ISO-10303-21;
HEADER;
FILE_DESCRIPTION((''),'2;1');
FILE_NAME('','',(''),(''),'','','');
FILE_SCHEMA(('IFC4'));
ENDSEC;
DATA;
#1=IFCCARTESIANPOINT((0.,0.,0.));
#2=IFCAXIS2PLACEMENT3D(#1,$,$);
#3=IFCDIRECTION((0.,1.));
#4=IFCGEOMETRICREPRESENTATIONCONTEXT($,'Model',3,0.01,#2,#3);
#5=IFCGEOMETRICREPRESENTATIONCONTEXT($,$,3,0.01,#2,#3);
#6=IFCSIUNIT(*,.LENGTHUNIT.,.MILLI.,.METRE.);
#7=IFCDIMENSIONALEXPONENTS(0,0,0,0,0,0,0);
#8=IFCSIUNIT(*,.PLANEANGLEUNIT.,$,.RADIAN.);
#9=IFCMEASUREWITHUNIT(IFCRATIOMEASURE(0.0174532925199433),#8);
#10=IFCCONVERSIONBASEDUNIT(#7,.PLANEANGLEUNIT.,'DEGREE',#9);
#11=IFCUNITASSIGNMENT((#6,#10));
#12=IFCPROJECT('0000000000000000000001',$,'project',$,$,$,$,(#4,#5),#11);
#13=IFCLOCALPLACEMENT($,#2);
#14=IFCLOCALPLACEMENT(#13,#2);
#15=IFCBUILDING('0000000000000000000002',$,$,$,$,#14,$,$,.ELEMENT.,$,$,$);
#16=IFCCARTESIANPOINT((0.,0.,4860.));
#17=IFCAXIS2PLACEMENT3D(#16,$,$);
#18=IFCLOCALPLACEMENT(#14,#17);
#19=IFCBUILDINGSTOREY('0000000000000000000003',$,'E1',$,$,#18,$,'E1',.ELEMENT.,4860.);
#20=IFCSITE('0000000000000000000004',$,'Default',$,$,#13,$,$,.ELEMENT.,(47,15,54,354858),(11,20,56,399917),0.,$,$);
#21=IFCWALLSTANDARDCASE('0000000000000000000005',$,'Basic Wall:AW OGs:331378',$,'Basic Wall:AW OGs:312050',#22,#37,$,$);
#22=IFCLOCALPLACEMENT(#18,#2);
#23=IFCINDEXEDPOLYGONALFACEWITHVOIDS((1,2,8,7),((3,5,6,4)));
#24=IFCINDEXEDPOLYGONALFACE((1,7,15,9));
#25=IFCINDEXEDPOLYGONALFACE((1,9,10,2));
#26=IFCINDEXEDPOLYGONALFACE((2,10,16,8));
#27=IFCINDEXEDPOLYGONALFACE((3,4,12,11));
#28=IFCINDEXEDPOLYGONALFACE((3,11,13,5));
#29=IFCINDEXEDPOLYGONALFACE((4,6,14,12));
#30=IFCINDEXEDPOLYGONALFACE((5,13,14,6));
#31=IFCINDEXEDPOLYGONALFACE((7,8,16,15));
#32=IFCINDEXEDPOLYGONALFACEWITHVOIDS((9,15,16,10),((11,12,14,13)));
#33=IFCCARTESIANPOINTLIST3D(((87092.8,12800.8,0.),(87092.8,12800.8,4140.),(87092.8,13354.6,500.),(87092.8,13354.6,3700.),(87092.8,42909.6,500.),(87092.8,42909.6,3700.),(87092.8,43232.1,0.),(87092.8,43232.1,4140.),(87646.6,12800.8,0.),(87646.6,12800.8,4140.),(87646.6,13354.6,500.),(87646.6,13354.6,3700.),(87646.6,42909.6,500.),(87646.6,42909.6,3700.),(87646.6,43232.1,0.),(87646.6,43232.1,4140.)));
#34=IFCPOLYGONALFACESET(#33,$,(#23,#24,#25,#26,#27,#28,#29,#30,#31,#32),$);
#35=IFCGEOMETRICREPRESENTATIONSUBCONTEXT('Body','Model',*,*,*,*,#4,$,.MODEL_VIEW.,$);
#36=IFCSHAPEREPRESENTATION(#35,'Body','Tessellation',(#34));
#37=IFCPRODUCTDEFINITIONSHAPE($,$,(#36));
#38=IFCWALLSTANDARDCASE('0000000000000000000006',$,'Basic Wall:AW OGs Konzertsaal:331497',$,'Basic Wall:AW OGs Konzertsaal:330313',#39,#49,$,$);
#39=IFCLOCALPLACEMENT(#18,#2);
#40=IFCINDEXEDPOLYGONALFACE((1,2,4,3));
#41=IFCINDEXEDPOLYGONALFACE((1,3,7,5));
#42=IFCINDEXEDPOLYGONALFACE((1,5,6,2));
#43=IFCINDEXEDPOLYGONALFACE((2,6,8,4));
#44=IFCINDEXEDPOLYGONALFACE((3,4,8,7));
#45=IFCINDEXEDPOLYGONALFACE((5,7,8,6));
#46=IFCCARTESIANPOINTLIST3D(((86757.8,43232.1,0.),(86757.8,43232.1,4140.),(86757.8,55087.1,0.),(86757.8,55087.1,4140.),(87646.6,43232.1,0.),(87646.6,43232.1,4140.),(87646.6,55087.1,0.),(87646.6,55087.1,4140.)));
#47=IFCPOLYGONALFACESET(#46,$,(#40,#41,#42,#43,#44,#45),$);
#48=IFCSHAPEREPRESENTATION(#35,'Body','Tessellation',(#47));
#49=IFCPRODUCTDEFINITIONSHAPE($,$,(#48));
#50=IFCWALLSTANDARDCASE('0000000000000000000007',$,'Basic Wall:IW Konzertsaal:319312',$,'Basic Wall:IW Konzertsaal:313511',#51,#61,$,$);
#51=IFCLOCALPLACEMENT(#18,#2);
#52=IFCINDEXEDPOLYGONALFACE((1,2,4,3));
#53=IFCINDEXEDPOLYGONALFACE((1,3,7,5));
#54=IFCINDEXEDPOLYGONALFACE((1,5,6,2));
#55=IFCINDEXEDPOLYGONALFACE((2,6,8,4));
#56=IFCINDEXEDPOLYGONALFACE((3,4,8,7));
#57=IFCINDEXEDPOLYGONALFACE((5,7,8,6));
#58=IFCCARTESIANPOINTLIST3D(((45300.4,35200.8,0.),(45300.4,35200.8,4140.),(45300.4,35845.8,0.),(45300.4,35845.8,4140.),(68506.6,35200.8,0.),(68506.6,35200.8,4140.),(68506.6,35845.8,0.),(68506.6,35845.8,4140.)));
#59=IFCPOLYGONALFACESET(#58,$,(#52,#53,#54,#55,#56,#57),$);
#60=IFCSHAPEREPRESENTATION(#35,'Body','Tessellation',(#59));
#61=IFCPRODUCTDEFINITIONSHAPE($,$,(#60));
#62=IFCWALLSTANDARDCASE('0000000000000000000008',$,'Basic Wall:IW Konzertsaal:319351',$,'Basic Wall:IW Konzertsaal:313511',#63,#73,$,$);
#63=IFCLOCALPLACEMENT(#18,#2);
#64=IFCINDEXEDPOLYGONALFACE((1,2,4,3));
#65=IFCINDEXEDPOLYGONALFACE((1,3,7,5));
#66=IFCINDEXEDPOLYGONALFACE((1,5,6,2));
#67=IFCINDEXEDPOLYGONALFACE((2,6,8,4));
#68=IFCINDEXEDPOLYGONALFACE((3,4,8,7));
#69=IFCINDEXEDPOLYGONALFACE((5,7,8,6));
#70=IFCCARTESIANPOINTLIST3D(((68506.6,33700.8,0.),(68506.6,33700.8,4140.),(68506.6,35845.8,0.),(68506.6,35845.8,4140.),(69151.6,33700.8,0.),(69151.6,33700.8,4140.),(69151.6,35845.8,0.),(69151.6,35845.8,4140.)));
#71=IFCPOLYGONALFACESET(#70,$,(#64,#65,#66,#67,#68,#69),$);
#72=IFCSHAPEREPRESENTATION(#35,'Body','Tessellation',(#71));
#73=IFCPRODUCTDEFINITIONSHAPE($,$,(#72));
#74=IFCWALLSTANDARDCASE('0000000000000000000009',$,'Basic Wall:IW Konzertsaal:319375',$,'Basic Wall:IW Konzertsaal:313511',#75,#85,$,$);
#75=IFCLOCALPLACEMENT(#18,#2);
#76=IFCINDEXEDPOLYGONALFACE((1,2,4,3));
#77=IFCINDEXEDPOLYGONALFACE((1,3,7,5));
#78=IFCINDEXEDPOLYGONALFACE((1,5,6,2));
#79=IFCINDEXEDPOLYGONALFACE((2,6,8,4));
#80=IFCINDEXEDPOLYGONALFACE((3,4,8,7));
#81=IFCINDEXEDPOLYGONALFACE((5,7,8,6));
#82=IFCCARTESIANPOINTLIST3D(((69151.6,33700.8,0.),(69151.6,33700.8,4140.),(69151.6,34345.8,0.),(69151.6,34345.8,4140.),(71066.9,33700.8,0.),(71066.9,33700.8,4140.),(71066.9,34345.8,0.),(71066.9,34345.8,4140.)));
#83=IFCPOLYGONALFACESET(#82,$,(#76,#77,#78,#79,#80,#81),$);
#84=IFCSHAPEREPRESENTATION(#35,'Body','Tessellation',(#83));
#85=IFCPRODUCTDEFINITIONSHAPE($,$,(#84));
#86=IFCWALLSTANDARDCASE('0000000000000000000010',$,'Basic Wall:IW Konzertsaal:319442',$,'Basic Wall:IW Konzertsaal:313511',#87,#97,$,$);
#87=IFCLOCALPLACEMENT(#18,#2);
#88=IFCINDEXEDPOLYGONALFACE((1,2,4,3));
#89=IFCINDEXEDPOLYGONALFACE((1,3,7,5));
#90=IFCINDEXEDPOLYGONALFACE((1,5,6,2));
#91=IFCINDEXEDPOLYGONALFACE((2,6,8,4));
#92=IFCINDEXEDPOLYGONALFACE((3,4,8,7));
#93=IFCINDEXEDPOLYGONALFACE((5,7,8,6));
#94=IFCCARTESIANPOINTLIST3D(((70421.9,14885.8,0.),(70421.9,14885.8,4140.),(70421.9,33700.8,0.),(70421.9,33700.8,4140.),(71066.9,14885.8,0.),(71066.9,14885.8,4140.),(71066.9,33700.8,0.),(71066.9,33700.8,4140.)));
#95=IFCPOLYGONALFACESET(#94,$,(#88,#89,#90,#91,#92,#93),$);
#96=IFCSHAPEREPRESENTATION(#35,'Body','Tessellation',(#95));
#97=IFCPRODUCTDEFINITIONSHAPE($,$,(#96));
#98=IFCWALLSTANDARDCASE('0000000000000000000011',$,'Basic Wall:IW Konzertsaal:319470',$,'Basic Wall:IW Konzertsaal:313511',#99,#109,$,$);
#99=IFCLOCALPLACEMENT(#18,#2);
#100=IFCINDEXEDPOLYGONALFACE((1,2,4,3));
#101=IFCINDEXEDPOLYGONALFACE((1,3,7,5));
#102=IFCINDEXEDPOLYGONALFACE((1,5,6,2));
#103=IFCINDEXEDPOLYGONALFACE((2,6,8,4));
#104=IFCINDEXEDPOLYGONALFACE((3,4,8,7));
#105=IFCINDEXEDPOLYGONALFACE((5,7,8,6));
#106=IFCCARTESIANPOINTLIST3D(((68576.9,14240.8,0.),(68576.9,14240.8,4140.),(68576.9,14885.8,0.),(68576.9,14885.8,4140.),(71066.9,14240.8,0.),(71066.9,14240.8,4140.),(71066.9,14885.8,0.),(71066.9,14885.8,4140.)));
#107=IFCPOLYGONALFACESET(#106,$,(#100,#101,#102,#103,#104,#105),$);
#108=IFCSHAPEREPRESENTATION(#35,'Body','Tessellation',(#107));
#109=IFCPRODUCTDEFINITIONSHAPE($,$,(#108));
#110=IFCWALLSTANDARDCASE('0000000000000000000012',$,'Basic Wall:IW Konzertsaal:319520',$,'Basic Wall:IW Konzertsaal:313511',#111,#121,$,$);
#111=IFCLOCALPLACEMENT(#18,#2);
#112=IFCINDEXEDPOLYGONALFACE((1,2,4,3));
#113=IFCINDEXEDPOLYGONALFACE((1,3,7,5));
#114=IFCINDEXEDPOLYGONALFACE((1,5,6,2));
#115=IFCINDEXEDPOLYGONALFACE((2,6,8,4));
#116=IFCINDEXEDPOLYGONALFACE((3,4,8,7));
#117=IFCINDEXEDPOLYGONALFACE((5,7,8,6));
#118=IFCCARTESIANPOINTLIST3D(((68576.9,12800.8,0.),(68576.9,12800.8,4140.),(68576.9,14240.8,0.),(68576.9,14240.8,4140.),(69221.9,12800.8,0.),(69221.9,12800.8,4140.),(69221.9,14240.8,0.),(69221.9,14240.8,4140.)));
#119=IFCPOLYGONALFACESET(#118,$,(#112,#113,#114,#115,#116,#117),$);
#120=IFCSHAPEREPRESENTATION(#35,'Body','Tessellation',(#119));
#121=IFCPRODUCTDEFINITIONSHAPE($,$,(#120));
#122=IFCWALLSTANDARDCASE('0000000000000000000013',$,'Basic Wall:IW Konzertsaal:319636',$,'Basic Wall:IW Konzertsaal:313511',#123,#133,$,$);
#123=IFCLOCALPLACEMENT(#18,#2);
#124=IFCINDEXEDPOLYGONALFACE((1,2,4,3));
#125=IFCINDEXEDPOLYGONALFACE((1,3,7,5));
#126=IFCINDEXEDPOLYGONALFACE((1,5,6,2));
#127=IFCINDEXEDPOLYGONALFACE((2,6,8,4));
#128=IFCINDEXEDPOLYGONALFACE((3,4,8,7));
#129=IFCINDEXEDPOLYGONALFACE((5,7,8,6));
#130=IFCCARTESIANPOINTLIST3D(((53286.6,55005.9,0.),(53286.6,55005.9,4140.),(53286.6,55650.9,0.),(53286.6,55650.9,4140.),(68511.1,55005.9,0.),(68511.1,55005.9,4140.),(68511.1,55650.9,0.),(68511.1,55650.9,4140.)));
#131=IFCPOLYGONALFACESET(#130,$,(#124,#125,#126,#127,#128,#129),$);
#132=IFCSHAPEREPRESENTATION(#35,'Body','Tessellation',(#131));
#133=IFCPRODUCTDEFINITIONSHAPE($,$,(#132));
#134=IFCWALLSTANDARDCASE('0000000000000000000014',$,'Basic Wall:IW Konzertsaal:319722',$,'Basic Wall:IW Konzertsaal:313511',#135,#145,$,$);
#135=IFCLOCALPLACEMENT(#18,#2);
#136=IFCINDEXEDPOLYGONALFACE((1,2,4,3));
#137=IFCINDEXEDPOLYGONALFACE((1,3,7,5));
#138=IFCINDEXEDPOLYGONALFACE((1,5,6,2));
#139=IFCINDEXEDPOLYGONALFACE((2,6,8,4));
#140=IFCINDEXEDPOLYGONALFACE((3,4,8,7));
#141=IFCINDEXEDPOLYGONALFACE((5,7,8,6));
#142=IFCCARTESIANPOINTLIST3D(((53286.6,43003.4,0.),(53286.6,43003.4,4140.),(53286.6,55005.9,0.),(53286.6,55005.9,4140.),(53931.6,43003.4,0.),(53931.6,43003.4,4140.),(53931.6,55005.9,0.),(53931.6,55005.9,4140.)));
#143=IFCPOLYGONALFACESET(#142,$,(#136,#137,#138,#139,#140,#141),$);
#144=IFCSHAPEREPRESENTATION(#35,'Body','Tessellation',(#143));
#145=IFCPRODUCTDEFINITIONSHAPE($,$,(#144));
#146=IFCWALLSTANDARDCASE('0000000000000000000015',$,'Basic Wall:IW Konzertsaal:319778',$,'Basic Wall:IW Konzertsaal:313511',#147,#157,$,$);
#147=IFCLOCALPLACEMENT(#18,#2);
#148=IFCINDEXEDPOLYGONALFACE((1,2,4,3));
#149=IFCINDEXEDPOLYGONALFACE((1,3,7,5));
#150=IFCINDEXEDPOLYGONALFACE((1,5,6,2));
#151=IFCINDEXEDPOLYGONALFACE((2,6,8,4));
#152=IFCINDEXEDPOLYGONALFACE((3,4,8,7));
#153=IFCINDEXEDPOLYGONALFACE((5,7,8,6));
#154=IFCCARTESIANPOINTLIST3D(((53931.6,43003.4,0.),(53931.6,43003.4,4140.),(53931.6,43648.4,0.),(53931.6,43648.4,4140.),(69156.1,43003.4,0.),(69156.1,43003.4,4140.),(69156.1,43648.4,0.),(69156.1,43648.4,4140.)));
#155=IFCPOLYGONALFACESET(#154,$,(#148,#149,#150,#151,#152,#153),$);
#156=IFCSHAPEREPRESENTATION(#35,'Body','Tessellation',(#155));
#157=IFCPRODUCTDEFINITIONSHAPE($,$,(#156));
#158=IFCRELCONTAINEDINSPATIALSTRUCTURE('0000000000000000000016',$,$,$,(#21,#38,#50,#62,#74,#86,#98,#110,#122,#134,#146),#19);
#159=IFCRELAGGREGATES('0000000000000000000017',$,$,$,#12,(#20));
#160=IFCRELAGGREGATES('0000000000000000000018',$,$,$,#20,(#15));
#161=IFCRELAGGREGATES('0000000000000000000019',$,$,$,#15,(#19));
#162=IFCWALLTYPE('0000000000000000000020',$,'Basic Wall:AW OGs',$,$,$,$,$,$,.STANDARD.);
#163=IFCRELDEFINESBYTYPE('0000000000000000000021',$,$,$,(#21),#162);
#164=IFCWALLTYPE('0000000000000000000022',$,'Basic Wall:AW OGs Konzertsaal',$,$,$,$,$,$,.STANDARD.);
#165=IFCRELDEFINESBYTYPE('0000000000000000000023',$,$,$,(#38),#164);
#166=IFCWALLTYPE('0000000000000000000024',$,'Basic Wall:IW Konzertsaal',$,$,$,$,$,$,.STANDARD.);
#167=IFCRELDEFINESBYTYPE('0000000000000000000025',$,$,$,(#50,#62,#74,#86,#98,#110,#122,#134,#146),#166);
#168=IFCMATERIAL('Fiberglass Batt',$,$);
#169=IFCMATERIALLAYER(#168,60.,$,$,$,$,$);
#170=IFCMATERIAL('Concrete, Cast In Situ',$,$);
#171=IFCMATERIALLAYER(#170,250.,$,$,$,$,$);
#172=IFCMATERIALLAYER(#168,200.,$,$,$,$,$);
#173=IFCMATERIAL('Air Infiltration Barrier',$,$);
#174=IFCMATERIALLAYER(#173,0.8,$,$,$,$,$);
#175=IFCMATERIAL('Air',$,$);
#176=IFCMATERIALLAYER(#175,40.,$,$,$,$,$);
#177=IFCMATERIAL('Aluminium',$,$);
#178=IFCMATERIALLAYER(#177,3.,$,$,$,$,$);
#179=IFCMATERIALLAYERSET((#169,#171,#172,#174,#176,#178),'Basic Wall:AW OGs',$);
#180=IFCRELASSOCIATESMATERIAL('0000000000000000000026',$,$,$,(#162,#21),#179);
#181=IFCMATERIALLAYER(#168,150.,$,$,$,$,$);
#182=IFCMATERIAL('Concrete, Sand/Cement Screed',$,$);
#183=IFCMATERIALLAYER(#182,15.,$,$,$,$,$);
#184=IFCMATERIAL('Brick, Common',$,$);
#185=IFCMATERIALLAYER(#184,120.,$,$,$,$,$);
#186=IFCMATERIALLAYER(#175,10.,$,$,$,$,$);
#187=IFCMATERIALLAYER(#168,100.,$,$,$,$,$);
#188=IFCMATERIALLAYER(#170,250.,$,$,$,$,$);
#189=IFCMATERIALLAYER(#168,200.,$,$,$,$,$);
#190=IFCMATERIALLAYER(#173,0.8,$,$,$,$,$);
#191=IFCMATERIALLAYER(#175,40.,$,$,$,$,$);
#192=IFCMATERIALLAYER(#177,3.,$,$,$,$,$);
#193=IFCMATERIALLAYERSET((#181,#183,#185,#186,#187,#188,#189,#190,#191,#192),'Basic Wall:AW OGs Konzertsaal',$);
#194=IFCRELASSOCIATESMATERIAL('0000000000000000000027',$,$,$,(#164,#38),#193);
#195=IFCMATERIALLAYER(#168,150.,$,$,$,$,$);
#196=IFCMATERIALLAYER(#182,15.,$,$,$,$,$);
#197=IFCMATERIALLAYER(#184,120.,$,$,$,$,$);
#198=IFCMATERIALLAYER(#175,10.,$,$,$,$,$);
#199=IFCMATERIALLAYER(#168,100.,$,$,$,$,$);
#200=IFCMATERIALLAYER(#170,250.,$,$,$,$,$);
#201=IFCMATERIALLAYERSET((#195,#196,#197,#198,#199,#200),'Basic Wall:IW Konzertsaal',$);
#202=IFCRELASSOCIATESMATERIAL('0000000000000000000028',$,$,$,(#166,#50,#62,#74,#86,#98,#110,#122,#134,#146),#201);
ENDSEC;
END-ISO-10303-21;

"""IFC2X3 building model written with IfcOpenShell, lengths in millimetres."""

from ifc_helpers import new_model, entity, si_unit, converted_unit, direction, frame, frame_2d, origin, place, context, subcontext, project, spatial, rectangle, extrude, material, layer, layer_set, layer_usage, type_object, element, save


model = new_model("IFC2X3")

# Units and contexts
model_context = context("Model", 3, precision=0.01, world=origin(), true_north=direction((0.0, 1.0)))
context_of_model = context(None, 3, precision=0.01, world=origin(), true_north=direction((0.0, 1.0)))
body_context = subcontext(model_context, "Body", "Model", "MODEL_VIEW")
ifc_project = project(units=[si_unit("LENGTHUNIT", "METRE", prefix="MILLI"), converted_unit("PLANEANGLEUNIT", "DEGREE", entity("IfcRatioMeasure", 0.0174532925199433), si_unit("PLANEANGLEUNIT", "RADIAN"), dimensions=[0, 0, 0, 0, 0, 0, 0])], contexts=[model_context, context_of_model])

# Site, building, storey
site_placement = place(None, origin())
site = spatial("IfcSite", under=ifc_project, at=site_placement, Name="Default", CompositionType="ELEMENT", RefLatitude=(47, 15, 54, 354858), RefLongitude=(11, 20, 56, 399917), RefElevation=0.0)
building_placement = place(site_placement, origin())
building = spatial("IfcBuilding", under=site, at=building_placement, CompositionType="ELEMENT")
storey_placement = place(building_placement, frame((0.0, 0.0, 4860.0)))
storey = spatial("IfcBuildingStorey", under=building, at=storey_placement, Name="E1", LongName="E1", CompositionType="ELEMENT", Elevation=4860.0)

# Shared definitions
ifc_material_1 = material(Name="Concrete, Sand/Cement Screed")
ifc_material_2 = material(Name="Air Infiltration Barrier")
ifc_material_3 = material(Name="Fiberglass Batt")

# Shared definitions
ifc_material_4 = material(Name="Aluminium")

# Shared definitions
ifc_material_5 = material(Name="Concrete, Cast In Situ")

# Shared definitions
ifc_layer_1 = layer(ifc_material_3, 60.0)
ifc_layer_2 = layer(ifc_material_5, 250.0)
ifc_layer_3 = layer(ifc_material_3, 200.0)
ifc_layer_4 = layer(ifc_material_2, 0.8)
ifc_material_6 = material(Name="Air")
ifc_layer_5 = layer(ifc_material_6, 40.0)
ifc_layer_6 = layer(ifc_material_4, 3.0)
ifc_layer_set_1 = layer_set([ifc_layer_1, ifc_layer_2, ifc_layer_3, ifc_layer_4, ifc_layer_5, ifc_layer_6], Name="Basic Wall:AW OGs")
wall_type_1 = type_object("IfcWallType", Name="Basic Wall:AW OGs", PredefinedType="STANDARD", material=ifc_layer_set_1)

# Wall, openings
ifc_layer_usage_1 = layer_usage(ifc_layer_set_1, "AXIS2", "POSITIVE", -276.9)
wall_1_placement = place(storey_placement, frame((87369.7, 43232.1, 0.0), z_axis=(0.0, 0.0, 1.0), x_axis=(0.0, -1.0, 0.0)))
wall_1 = element("IfcWallStandardCase", 1, at=wall_1_placement, inside=storey, type_object=wall_type_1, material=ifc_layer_usage_1, Name="Basic Wall:AW OGs:331378", ObjectType="Basic Wall:AW OGs:312050", context=body_context, shape_type="SweptSolid", body=[
    extrude(rectangle(XDim=30431.3, YDim=553.8, at=frame_2d((15215.6, 0.0), x_axis=(-1.0, 0.0))), origin(), (0.0, 0.0, 1.0), 4140.0),
])
opening_1_placement = place(wall_1_placement, origin())
element("IfcOpeningElement", 2, at=opening_1_placement, cuts=wall_1, ObjectType="Opening", context=body_context, shape_type="SweptSolid", body=[
    extrude(rectangle(XDim=3200.0, YDim=553.8, at=frame_2d((0.0, 0.0), x_axis=(0.0, 1.0))), frame((30154.4, -17857.8, 2100.0), z_axis=(0.0, 1.0, 0.0), x_axis=(1.0, 0.0, 0.0)), (0.0, 0.0, 1.0), 17560.0),
])
opening_2_placement = place(wall_1_placement, frame((322.5, -276.9, 500.0)))
element("IfcOpeningElement", 3, at=opening_2_placement, cuts=wall_1, ObjectType="Opening", context=body_context, shape_type="SweptSolid", body=[
    extrude(rectangle(XDim=3200.0, YDim=29555.0, at=frame_2d((1600.0, 14777.5), x_axis=(-1.0, 0.0))), frame((0.0, 0.0, 0.0), z_axis=(0.0, 1.0, 0.0), x_axis=(0.0, 0.0, 1.0)), (0.0, 0.0, 1.0), 553.8),
])

# Walls
ifc_layer_7 = layer(ifc_material_3, 150.0)
ifc_layer_8 = layer(ifc_material_1, 15.0)
ifc_material_7 = material(Name="Brick, Common")
ifc_layer_9 = layer(ifc_material_7, 120.0)
ifc_layer_10 = layer(ifc_material_6, 10.0)
ifc_layer_11 = layer(ifc_material_3, 100.0)
ifc_layer_12 = layer(ifc_material_5, 250.0)
ifc_layer_13 = layer(ifc_material_3, 200.0)
ifc_layer_14 = layer(ifc_material_2, 0.8)
ifc_layer_15 = layer(ifc_material_6, 40.0)
ifc_layer_16 = layer(ifc_material_4, 3.0)
ifc_layer_set_2 = layer_set([ifc_layer_7, ifc_layer_8, ifc_layer_9, ifc_layer_10, ifc_layer_11, ifc_layer_12, ifc_layer_13, ifc_layer_14, ifc_layer_15, ifc_layer_16], Name="Basic Wall:AW OGs Konzertsaal")
ifc_layer_usage_2 = layer_usage(ifc_layer_set_2, "AXIS2", "POSITIVE", -444.4)
wall_type_2 = type_object("IfcWallType", Name="Basic Wall:AW OGs Konzertsaal", PredefinedType="STANDARD", material=ifc_layer_set_2)
wall_2_placement = place(storey_placement, frame((87202.2, 55087.1, 0.0), z_axis=(0.0, 0.0, 1.0), x_axis=(0.0, -1.0, 0.0)))
element("IfcWallStandardCase", 4, at=wall_2_placement, inside=storey, type_object=wall_type_2, material=ifc_layer_usage_2, Name="Basic Wall:AW OGs Konzertsaal:331497", ObjectType="Basic Wall:AW OGs Konzertsaal:330313", context=body_context, shape_type="SweptSolid", body=[
    extrude(rectangle(XDim=11855.0, YDim=888.8, at=frame_2d((5927.5, 0.0), x_axis=(-1.0, 0.0))), origin(), (0.0, 0.0, 1.0), 4140.0),
])
ifc_layer_17 = layer(ifc_material_3, 150.0)
ifc_layer_18 = layer(ifc_material_1, 15.0)
ifc_layer_19 = layer(ifc_material_7, 120.0)
ifc_layer_20 = layer(ifc_material_6, 10.0)
ifc_layer_21 = layer(ifc_material_3, 100.0)
ifc_layer_22 = layer(ifc_material_5, 250.0)
ifc_layer_set_3 = layer_set([ifc_layer_17, ifc_layer_18, ifc_layer_19, ifc_layer_20, ifc_layer_21, ifc_layer_22], Name="Basic Wall:IW Konzertsaal")
ifc_layer_usage_3 = layer_usage(ifc_layer_set_3, "AXIS2", "POSITIVE", -322.5)
wall_type_3 = type_object("IfcWallType", Name="Basic Wall:IW Konzertsaal", PredefinedType="STANDARD", material=ifc_layer_set_3)
wall_3_placement = place(storey_placement, frame((45300.4, 35523.3, 0.0)))
element("IfcWallStandardCase", 5, at=wall_3_placement, inside=storey, type_object=wall_type_3, material=ifc_layer_usage_3, Name="Basic Wall:IW Konzertsaal:319312", ObjectType="Basic Wall:IW Konzertsaal:313511", context=body_context, shape_type="SweptSolid", body=[
    extrude(rectangle(XDim=23206.2, YDim=645.0, at=frame_2d((11603.1, 0.0), x_axis=(-1.0, 0.0))), origin(), (0.0, 0.0, 1.0), 4140.0),
])
ifc_layer_usage_4 = layer_usage(ifc_layer_set_3, "AXIS2", "POSITIVE", -322.5)
wall_4_placement = place(storey_placement, frame((68829.1, 35845.8, 0.0), z_axis=(0.0, 0.0, 1.0), x_axis=(0.0, -1.0, 0.0)))
element("IfcWallStandardCase", 6, at=wall_4_placement, inside=storey, type_object=wall_type_3, material=ifc_layer_usage_4, Name="Basic Wall:IW Konzertsaal:319351", ObjectType="Basic Wall:IW Konzertsaal:313511", context=body_context, shape_type="SweptSolid", body=[
    extrude(rectangle(XDim=2145.0, YDim=645.0, at=frame_2d((1072.5, 0.0), x_axis=(-1.0, 0.0))), origin(), (0.0, 0.0, 1.0), 4140.0),
])
ifc_layer_usage_5 = layer_usage(ifc_layer_set_3, "AXIS2", "POSITIVE", -322.5)
wall_5_placement = place(storey_placement, frame((69151.6, 34023.3, 0.0)))
element("IfcWallStandardCase", 7, at=wall_5_placement, inside=storey, type_object=wall_type_3, material=ifc_layer_usage_5, Name="Basic Wall:IW Konzertsaal:319375", ObjectType="Basic Wall:IW Konzertsaal:313511", context=body_context, shape_type="SweptSolid", body=[
    extrude(rectangle(XDim=1915.3, YDim=645.0, at=frame_2d((957.7, 0.0), x_axis=(-1.0, 0.0))), origin(), (0.0, 0.0, 1.0), 4140.0),
])
ifc_layer_usage_6 = layer_usage(ifc_layer_set_3, "AXIS2", "POSITIVE", -322.5)
wall_6_placement = place(storey_placement, frame((70744.4, 33700.8, 0.0), z_axis=(0.0, 0.0, 1.0), x_axis=(0.0, -1.0, 0.0)))
element("IfcWallStandardCase", 8, at=wall_6_placement, inside=storey, type_object=wall_type_3, material=ifc_layer_usage_6, Name="Basic Wall:IW Konzertsaal:319442", ObjectType="Basic Wall:IW Konzertsaal:313511", context=body_context, shape_type="SweptSolid", body=[
    extrude(rectangle(XDim=18815.0, YDim=645.0, at=frame_2d((9407.5, 0.0), x_axis=(-1.0, 0.0))), origin(), (0.0, 0.0, 1.0), 4140.0),
])
ifc_layer_usage_7 = layer_usage(ifc_layer_set_3, "AXIS2", "POSITIVE", -322.5)
wall_7_placement = place(storey_placement, frame((71066.9, 14563.3, 0.0), z_axis=(0.0, 0.0, 1.0), x_axis=(-1.0, 0.0, 0.0)))
element("IfcWallStandardCase", 9, at=wall_7_placement, inside=storey, type_object=wall_type_3, material=ifc_layer_usage_7, Name="Basic Wall:IW Konzertsaal:319470", ObjectType="Basic Wall:IW Konzertsaal:313511", context=body_context, shape_type="SweptSolid", body=[
    extrude(rectangle(XDim=2490.0, YDim=645.0, at=frame_2d((1245.0, 0.0), x_axis=(-1.0, 0.0))), origin(), (0.0, 0.0, 1.0), 4140.0),
])
ifc_layer_usage_8 = layer_usage(ifc_layer_set_3, "AXIS2", "POSITIVE", -322.5)
wall_8_placement = place(storey_placement, frame((68899.4, 14240.8, 0.0), z_axis=(0.0, 0.0, 1.0), x_axis=(0.0, -1.0, 0.0)))
element("IfcWallStandardCase", 10, at=wall_8_placement, inside=storey, type_object=wall_type_3, material=ifc_layer_usage_8, Name="Basic Wall:IW Konzertsaal:319520", ObjectType="Basic Wall:IW Konzertsaal:313511", context=body_context, shape_type="SweptSolid", body=[
    extrude(rectangle(XDim=1440.0, YDim=645.0, at=frame_2d((720.0, 0.0), x_axis=(-1.0, 0.0))), origin(), (0.0, 0.0, 1.0), 4140.0),
])
ifc_layer_usage_9 = layer_usage(ifc_layer_set_3, "AXIS2", "NEGATIVE", 322.5)
wall_9_placement = place(storey_placement, frame((68511.1, 55328.4, 0.0), z_axis=(0.0, 0.0, 1.0), x_axis=(-1.0, 0.0, 0.0)))
element("IfcWallStandardCase", 11, at=wall_9_placement, inside=storey, type_object=wall_type_3, material=ifc_layer_usage_9, Name="Basic Wall:IW Konzertsaal:319636", ObjectType="Basic Wall:IW Konzertsaal:313511", context=body_context, shape_type="SweptSolid", body=[
    extrude(rectangle(XDim=15224.5, YDim=645.0, at=frame_2d((7612.3, 0.0), x_axis=(-1.0, 0.0))), origin(), (0.0, 0.0, 1.0), 4140.0),
])
ifc_layer_usage_10 = layer_usage(ifc_layer_set_3, "AXIS2", "NEGATIVE", 322.5)
wall_10_placement = place(storey_placement, frame((53609.1, 55005.9, 0.0), z_axis=(0.0, 0.0, 1.0), x_axis=(0.0, -1.0, 0.0)))
element("IfcWallStandardCase", 12, at=wall_10_placement, inside=storey, type_object=wall_type_3, material=ifc_layer_usage_10, Name="Basic Wall:IW Konzertsaal:319722", ObjectType="Basic Wall:IW Konzertsaal:313511", context=body_context, shape_type="SweptSolid", body=[
    extrude(rectangle(XDim=12002.4, YDim=645.0, at=frame_2d((6001.2, 0.0), x_axis=(-1.0, 0.0))), origin(), (0.0, 0.0, 1.0), 4140.0),
])
ifc_layer_usage_11 = layer_usage(ifc_layer_set_3, "AXIS2", "NEGATIVE", 322.5)
wall_11_placement = place(storey_placement, frame((53931.6, 43325.9, 0.0)))
element("IfcWallStandardCase", 13, at=wall_11_placement, inside=storey, type_object=wall_type_3, material=ifc_layer_usage_11, Name="Basic Wall:IW Konzertsaal:319778", ObjectType="Basic Wall:IW Konzertsaal:313511", context=body_context, shape_type="SweptSolid", body=[
    extrude(rectangle(XDim=15224.5, YDim=645.0, at=frame_2d((7612.3, 0.0), x_axis=(-1.0, 0.0))), origin(), (0.0, 0.0, 1.0), 4140.0),
])

save(model, "model.ifc")
